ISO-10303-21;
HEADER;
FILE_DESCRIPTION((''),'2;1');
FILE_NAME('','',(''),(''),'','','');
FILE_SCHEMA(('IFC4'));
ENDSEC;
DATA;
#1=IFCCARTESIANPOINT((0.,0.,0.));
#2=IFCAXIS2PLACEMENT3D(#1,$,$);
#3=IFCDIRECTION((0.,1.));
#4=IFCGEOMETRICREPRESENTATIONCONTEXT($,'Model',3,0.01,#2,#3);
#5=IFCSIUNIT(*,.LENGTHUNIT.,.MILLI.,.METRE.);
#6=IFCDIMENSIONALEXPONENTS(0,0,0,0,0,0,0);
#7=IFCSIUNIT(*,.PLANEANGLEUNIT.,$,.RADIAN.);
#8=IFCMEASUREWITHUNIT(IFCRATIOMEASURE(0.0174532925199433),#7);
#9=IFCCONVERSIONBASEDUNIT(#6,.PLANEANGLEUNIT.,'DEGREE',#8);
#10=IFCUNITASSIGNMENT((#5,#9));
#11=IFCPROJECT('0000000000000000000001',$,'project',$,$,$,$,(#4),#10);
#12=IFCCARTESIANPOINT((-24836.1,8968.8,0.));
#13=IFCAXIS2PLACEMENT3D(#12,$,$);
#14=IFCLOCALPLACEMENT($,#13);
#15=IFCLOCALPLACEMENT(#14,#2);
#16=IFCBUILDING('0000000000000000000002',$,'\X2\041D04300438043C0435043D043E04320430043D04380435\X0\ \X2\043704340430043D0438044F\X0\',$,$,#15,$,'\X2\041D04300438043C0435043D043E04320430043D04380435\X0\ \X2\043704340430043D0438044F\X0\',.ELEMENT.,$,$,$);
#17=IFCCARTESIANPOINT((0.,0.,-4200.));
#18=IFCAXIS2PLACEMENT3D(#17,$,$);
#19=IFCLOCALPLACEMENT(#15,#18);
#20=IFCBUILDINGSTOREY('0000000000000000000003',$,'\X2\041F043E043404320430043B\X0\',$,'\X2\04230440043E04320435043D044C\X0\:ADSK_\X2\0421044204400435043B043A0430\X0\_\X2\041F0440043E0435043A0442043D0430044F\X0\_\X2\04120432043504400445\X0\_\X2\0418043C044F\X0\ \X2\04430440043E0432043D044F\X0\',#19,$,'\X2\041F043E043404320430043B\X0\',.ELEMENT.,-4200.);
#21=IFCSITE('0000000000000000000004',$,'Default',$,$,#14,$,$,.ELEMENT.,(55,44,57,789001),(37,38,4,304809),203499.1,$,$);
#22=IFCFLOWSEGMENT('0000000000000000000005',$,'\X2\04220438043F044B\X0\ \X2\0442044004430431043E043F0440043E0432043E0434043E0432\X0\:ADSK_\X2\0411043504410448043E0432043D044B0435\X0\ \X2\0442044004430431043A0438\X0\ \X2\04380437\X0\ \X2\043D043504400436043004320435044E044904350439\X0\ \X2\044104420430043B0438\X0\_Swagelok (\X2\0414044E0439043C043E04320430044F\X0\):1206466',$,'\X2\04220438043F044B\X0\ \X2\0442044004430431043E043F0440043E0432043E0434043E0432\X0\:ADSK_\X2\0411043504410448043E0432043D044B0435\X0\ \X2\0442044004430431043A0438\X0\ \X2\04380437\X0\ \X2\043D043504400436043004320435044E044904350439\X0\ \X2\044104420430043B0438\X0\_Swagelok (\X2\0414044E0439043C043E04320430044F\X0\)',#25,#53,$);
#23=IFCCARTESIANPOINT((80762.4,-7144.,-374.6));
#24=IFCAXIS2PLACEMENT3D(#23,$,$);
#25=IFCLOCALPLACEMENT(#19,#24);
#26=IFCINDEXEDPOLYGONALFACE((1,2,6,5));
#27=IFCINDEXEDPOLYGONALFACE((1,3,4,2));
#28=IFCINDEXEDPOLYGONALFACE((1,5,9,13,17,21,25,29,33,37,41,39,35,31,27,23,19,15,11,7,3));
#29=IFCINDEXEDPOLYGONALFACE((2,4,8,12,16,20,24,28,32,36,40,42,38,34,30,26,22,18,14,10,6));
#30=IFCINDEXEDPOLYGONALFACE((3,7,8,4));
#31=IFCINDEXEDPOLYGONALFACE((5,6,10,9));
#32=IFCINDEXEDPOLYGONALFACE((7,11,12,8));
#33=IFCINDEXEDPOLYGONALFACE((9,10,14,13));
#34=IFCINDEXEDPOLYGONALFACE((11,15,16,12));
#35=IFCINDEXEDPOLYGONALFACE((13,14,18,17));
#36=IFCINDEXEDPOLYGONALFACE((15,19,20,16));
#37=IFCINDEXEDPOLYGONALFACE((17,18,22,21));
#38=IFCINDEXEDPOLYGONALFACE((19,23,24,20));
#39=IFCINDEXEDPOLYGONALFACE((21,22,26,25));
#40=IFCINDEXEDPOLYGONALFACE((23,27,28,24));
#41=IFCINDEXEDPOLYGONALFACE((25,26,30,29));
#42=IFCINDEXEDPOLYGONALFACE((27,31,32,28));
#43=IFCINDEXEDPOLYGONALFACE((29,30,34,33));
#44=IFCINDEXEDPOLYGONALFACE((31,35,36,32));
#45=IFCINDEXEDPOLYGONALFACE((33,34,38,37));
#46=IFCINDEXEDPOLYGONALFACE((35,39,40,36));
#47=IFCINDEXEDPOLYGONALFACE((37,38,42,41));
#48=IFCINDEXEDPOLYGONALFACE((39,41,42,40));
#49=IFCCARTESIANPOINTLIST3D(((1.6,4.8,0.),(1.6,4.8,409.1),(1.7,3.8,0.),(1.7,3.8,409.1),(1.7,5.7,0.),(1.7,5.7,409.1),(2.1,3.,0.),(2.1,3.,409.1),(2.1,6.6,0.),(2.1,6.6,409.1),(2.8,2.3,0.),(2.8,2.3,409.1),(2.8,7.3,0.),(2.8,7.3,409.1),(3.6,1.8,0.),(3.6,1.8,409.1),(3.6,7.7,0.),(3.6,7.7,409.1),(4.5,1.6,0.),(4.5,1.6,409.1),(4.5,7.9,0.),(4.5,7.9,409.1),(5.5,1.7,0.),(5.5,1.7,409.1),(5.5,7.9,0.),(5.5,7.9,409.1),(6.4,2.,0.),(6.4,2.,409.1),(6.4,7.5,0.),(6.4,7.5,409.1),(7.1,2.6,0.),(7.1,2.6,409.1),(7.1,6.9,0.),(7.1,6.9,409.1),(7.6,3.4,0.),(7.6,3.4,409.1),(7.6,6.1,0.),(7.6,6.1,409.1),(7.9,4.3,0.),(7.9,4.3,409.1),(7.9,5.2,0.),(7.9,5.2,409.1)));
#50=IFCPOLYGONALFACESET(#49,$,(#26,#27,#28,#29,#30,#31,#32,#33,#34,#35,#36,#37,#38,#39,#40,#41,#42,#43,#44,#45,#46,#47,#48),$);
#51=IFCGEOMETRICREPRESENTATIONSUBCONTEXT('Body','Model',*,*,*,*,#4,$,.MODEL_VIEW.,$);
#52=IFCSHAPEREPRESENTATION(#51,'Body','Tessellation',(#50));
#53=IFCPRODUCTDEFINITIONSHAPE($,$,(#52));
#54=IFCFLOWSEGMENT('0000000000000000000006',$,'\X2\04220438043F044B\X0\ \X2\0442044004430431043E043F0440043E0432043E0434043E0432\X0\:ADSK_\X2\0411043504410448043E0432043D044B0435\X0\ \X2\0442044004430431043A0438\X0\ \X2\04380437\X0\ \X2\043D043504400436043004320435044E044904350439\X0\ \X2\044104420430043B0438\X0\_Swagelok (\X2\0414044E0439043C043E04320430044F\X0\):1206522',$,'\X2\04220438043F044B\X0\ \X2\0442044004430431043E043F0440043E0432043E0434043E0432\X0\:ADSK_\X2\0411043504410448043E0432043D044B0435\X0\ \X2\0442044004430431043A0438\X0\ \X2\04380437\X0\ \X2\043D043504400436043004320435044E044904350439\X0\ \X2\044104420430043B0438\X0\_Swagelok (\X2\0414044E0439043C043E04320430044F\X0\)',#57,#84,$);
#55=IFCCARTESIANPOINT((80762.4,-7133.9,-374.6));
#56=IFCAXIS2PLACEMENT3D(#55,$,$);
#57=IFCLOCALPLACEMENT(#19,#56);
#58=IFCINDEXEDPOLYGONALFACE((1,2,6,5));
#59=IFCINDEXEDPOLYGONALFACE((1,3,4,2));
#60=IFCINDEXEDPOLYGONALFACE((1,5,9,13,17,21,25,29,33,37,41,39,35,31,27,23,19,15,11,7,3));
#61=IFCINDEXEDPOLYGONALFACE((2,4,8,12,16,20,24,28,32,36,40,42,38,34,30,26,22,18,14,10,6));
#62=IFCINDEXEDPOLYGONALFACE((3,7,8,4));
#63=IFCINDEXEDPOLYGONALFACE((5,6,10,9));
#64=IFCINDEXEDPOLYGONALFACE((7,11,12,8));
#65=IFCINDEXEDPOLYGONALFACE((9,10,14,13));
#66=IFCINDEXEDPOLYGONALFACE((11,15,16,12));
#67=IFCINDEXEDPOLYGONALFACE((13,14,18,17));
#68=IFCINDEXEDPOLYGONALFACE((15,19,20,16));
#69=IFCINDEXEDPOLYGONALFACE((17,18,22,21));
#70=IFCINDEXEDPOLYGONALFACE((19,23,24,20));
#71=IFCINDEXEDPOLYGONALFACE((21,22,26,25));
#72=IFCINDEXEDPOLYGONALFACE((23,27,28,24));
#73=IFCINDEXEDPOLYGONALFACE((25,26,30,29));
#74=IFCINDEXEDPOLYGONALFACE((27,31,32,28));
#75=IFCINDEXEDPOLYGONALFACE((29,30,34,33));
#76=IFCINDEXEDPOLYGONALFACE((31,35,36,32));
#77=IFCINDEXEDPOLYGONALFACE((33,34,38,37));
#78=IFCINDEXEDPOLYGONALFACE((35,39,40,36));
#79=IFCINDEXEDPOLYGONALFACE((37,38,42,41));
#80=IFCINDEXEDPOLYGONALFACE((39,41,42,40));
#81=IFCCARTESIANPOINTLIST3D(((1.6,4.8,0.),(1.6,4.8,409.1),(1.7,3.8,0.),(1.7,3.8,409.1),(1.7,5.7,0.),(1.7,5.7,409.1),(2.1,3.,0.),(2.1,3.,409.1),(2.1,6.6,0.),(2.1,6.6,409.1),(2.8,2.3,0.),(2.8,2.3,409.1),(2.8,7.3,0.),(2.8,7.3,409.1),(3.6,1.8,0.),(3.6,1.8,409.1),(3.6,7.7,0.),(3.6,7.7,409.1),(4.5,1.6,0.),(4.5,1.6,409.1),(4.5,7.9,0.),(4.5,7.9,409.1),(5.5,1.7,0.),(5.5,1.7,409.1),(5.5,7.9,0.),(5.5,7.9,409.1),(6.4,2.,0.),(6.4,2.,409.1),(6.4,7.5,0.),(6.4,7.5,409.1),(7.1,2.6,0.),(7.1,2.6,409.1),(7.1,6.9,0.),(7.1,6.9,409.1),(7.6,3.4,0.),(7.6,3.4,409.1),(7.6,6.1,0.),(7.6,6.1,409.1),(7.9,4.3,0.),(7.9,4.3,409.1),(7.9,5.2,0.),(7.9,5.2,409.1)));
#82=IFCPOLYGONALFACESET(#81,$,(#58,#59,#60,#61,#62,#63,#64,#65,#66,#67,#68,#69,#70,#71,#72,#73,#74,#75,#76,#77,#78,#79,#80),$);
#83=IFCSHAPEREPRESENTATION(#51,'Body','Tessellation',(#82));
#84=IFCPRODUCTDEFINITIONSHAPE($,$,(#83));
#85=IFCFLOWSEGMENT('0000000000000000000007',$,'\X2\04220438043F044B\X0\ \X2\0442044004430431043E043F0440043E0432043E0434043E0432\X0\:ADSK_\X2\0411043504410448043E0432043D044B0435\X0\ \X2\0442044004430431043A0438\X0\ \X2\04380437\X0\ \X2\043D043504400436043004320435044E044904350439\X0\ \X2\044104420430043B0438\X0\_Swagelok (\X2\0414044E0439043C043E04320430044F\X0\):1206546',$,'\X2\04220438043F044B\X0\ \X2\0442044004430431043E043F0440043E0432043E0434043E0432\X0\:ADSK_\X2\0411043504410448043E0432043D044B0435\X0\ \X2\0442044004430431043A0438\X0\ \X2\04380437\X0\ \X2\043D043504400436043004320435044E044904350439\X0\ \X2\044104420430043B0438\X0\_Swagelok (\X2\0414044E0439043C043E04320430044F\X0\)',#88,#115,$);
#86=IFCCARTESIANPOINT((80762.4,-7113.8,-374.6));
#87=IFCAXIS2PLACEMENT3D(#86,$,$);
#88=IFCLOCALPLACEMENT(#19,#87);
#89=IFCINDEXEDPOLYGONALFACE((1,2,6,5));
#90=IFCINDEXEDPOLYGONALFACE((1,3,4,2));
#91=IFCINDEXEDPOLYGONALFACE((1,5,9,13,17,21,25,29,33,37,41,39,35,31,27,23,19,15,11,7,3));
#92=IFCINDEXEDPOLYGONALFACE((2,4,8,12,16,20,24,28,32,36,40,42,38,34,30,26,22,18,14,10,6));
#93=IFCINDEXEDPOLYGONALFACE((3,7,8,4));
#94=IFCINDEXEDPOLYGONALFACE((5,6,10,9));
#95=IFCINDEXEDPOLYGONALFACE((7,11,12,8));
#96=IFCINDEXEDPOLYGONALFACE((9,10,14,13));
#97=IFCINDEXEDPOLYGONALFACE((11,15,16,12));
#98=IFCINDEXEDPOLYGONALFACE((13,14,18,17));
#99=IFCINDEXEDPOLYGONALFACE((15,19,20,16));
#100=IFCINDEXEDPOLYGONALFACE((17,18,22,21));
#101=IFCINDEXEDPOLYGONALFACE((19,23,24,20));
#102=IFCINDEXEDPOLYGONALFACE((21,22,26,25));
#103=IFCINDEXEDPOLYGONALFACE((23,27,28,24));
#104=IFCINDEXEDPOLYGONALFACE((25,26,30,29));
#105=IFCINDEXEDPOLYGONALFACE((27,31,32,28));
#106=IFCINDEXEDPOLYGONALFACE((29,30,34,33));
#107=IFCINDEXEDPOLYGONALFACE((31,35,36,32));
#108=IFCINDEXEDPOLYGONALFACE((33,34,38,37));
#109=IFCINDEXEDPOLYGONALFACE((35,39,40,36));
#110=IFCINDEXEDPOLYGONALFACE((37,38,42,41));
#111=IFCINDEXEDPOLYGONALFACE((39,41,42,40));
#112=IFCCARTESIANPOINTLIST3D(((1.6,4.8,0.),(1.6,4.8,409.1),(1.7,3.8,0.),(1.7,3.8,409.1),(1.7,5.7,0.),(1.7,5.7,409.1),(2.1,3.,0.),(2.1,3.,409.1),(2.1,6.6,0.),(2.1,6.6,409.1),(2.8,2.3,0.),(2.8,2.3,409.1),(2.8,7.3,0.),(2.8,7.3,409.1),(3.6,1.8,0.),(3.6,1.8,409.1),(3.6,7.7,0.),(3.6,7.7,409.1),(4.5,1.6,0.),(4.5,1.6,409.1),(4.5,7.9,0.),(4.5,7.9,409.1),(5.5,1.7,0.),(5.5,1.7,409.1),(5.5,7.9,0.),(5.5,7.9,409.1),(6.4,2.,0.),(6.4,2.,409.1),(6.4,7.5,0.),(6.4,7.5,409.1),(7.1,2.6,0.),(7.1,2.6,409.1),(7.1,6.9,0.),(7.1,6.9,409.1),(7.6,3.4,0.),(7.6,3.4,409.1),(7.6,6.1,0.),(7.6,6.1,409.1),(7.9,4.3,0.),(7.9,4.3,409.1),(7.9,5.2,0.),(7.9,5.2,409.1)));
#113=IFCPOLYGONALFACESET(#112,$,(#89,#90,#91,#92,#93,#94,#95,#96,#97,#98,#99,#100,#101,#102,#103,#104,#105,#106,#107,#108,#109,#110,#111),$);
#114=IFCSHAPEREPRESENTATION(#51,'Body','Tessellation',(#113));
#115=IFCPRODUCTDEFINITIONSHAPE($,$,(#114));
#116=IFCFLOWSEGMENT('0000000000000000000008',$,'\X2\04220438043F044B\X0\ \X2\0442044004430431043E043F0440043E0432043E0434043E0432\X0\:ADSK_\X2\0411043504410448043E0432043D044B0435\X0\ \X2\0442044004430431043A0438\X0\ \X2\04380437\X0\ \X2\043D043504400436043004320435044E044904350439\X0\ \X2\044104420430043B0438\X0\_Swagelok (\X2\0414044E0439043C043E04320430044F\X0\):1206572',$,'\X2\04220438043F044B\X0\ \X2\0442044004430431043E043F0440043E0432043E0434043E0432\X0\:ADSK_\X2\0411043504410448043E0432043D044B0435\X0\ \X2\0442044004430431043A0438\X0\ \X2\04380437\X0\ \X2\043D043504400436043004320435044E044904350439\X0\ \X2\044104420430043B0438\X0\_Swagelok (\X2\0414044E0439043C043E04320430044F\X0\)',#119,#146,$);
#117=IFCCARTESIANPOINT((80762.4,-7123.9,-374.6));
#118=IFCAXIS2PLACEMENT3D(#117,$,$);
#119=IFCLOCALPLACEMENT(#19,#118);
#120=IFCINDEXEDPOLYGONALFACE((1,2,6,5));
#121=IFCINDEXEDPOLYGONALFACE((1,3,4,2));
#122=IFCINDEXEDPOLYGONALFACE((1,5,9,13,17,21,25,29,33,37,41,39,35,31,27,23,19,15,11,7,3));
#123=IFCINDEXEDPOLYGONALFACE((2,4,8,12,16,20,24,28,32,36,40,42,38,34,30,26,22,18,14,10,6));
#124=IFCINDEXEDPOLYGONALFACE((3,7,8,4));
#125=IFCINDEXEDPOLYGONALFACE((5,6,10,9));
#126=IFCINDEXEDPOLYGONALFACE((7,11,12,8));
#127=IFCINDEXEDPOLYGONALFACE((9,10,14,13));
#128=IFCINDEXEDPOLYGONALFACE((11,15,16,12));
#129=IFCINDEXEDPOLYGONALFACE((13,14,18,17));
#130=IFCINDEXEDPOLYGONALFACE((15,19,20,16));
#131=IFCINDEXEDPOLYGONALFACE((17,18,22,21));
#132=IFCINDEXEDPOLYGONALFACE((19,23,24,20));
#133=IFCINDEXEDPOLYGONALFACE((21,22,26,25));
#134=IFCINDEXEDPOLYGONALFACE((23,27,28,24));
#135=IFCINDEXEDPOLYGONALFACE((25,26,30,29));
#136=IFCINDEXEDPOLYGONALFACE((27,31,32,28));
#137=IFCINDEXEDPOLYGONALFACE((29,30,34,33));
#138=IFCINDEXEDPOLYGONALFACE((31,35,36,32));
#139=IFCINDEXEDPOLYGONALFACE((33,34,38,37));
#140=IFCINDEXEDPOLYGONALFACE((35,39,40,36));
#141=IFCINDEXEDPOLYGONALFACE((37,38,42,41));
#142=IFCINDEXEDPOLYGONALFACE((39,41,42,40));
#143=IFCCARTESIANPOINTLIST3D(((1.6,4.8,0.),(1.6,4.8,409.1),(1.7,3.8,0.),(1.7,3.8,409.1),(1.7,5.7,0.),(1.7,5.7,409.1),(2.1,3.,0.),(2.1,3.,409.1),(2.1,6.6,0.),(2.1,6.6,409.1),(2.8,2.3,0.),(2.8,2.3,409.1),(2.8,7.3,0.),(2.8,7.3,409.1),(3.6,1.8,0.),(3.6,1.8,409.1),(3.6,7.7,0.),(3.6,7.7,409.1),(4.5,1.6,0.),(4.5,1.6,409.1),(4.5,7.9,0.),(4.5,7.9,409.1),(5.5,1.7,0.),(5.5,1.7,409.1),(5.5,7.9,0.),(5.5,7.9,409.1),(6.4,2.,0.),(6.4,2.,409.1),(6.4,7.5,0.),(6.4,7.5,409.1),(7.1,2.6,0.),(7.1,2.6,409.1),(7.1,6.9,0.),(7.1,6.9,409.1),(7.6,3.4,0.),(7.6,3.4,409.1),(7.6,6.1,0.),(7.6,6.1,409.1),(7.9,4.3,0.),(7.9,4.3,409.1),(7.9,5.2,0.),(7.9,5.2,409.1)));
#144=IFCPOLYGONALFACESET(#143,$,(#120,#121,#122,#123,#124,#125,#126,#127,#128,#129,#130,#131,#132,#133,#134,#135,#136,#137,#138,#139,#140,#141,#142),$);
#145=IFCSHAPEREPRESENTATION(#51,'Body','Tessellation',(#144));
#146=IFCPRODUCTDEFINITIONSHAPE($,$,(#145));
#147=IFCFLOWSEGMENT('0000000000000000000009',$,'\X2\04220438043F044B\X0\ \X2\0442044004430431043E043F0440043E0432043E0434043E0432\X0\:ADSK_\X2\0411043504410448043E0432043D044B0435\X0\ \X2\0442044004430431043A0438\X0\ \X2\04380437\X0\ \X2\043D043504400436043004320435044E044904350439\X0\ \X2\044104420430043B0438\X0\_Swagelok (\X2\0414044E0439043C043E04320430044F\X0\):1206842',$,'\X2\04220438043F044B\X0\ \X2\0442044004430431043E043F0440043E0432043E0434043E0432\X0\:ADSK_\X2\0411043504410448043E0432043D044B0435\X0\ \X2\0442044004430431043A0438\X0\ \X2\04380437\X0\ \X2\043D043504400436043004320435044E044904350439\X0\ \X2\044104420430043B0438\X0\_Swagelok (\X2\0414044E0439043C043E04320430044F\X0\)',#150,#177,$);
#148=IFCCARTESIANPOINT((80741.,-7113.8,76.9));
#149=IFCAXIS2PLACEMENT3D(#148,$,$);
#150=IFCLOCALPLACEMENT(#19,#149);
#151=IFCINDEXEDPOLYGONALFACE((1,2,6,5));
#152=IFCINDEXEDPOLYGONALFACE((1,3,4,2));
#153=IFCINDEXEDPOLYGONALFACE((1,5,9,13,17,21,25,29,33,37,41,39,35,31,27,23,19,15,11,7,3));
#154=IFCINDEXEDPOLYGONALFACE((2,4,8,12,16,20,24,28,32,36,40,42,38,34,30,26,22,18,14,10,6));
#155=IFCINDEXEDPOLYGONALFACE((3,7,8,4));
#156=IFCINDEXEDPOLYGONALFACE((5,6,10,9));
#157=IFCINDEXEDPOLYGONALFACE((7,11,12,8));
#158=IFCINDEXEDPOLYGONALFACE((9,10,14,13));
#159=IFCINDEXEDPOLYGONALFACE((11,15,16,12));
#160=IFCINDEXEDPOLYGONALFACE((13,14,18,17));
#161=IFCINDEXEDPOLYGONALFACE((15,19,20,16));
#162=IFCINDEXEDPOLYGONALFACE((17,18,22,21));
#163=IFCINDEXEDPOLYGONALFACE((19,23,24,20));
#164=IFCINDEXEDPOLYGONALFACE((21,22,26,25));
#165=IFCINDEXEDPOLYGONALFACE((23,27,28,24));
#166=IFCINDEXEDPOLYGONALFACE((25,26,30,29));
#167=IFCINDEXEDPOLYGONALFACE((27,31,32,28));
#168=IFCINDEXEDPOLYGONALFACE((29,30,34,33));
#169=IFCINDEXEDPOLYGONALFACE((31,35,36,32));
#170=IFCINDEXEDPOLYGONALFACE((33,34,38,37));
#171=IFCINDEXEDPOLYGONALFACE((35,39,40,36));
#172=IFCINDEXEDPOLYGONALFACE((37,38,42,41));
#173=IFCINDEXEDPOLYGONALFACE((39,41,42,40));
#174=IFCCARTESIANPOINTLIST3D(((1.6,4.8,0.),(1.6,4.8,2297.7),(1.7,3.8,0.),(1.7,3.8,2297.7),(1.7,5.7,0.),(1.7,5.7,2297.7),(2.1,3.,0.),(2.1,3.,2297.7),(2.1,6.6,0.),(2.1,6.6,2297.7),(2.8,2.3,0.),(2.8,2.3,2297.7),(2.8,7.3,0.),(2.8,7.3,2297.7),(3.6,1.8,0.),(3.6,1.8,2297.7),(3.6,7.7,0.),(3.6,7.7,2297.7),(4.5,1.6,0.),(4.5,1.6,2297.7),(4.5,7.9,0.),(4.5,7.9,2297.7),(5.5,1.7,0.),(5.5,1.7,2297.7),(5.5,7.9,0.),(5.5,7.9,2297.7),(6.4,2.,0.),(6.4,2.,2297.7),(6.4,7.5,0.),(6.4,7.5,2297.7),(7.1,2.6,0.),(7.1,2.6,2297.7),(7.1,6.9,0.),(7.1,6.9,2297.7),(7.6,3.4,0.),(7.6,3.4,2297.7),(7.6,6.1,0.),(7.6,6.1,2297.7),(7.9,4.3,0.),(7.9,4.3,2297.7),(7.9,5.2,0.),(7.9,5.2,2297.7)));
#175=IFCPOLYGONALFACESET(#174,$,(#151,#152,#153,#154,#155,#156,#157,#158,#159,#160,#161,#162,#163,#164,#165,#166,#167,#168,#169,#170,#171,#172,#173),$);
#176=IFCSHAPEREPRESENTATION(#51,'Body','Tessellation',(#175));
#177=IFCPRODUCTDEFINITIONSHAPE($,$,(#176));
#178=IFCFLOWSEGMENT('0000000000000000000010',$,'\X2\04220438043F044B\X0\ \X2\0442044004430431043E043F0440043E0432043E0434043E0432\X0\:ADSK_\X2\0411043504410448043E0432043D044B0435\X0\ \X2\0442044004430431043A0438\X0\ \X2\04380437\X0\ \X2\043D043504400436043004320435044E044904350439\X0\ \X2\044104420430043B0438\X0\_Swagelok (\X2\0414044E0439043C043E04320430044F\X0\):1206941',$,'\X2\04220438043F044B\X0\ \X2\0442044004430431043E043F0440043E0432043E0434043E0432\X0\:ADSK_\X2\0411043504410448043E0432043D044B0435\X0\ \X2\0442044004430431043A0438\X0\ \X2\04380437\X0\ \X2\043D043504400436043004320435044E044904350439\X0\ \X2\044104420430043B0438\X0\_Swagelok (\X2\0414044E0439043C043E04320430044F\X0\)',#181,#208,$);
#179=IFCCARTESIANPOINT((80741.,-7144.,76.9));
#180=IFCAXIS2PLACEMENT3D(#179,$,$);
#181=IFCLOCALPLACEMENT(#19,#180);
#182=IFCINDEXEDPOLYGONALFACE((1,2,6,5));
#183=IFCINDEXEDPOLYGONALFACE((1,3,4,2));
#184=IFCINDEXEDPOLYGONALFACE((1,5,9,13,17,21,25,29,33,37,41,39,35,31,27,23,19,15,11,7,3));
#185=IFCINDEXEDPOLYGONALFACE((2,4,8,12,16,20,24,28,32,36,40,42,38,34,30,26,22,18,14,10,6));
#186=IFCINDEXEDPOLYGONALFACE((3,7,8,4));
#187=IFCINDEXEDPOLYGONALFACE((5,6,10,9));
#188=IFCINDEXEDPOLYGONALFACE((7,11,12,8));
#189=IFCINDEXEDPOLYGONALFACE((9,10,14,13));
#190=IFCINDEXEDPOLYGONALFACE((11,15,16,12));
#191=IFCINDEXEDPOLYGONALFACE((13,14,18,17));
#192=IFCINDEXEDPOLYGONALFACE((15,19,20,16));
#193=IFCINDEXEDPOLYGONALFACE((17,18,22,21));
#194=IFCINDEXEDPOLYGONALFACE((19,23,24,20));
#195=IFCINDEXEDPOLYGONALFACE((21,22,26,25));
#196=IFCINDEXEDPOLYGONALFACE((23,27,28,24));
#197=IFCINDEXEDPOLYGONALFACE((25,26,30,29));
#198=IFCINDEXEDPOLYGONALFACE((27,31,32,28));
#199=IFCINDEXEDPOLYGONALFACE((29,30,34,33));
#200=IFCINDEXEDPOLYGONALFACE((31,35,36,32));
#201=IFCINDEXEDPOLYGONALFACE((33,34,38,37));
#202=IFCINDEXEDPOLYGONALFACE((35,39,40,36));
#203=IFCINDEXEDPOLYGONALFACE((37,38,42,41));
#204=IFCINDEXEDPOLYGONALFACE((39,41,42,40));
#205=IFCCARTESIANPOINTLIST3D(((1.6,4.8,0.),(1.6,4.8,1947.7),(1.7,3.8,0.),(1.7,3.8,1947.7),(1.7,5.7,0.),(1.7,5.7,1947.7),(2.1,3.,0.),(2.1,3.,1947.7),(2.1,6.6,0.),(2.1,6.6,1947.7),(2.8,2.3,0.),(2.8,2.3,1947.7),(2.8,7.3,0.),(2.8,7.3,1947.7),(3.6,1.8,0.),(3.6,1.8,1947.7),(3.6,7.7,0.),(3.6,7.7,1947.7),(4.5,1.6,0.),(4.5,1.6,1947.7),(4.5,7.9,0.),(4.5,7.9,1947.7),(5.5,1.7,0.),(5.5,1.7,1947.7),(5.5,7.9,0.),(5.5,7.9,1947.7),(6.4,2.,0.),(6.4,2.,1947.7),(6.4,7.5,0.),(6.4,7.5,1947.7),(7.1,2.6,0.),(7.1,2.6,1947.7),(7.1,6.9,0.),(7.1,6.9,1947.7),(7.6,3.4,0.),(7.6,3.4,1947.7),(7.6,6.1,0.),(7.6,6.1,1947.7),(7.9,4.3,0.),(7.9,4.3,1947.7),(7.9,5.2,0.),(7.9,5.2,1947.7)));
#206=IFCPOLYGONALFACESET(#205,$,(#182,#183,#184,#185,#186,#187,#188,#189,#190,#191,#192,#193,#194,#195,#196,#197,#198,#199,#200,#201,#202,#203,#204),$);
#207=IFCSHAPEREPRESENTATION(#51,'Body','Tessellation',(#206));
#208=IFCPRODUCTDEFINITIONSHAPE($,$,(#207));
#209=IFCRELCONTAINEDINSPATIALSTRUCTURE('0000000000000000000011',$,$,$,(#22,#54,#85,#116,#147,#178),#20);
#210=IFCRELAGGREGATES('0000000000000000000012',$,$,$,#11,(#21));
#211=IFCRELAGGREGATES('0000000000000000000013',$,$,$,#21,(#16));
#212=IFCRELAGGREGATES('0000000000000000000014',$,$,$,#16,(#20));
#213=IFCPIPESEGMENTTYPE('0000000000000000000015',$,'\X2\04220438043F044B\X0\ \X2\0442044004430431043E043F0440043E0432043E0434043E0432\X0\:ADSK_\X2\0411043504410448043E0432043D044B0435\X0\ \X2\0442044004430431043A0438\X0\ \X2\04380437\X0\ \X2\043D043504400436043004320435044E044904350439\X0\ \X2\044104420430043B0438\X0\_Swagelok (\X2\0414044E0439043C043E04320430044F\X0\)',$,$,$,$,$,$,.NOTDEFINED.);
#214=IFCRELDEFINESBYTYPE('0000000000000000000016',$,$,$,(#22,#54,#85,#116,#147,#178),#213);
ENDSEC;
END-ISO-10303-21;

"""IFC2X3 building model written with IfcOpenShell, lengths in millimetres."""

from ifc_helpers import new_model, entity, si_unit, converted_unit, direction, frame, origin, origin_2d_with_axis, place, context, subcontext, project, spatial, circle, extrude, type_object, element, save


model = new_model("IFC2X3")

# Units and contexts
model_context = context("Model", 3, precision=0.01, world=origin(), true_north=direction((0.0, 1.0)))
body_context = subcontext(model_context, "Body", "Model", "MODEL_VIEW")
ifc_project = project(units=[si_unit("LENGTHUNIT", "METRE", prefix="MILLI"), converted_unit("PLANEANGLEUNIT", "DEGREE", entity("IfcRatioMeasure", 0.0174532925199433), si_unit("PLANEANGLEUNIT", "RADIAN"), dimensions=[0, 0, 0, 0, 0, 0, 0])], contexts=[model_context])

# Site, building, storey
site_placement = place(None, frame((-24836.1, 8968.8, 0.0)))
site = spatial("IfcSite", under=ifc_project, at=site_placement, Name="Default", CompositionType="ELEMENT", RefLatitude=(55, 44, 57, 789001), RefLongitude=(37, 38, 4, 304809), RefElevation=203499.1)
building_placement = place(site_placement, origin())
building = spatial("IfcBuilding", under=site, at=building_placement, Name="Наименование здания", LongName="Наименование здания", CompositionType="ELEMENT")
storey_placement = place(building_placement, frame((0.0, 0.0, -4200.0)))
storey = spatial("IfcBuildingStorey", under=building, at=storey_placement, Name="Подвал", ObjectType="Уровень:ADSK_Стрелка_Проектная_Вверх_Имя уровня", LongName="Подвал", CompositionType="ELEMENT", Elevation=-4200.0)

# Flow segments
pipe_segment_type_1 = type_object("IfcPipeSegmentType", Name="Типы трубопроводов:ADSK_Бесшовные трубки из нержавеющей стали_Swagelok (Дюймовая)", PredefinedType="NOTDEFINED")
flow_segment_1_placement = place(storey_placement, frame((80762.4, -7144.0, -374.6)))
element("IfcFlowSegment", 1, at=flow_segment_1_placement, inside=storey, type_object=pipe_segment_type_1, Name="Типы трубопроводов:ADSK_Бесшовные трубки из нержавеющей стали_Swagelok (Дюймовая):1206466", ObjectType="Типы трубопроводов:ADSK_Бесшовные трубки из нержавеющей стали_Swagelok (Дюймовая)", context=body_context, shape_type="SweptSolid", body=[
    extrude(circle(Radius=3.2, at=origin_2d_with_axis()), frame((4.8, 4.8, 0.0), z_axis=(0.0, 0.0, 1.0), x_axis=(-1.0, 0.0, 0.0)), (0.0, 0.0, 1.0), 409.1),
])
flow_segment_2_placement = place(storey_placement, frame((80762.4, -7133.9, -374.6)))
element("IfcFlowSegment", 2, at=flow_segment_2_placement, inside=storey, type_object=pipe_segment_type_1, Name="Типы трубопроводов:ADSK_Бесшовные трубки из нержавеющей стали_Swagelok (Дюймовая):1206522", ObjectType="Типы трубопроводов:ADSK_Бесшовные трубки из нержавеющей стали_Swagelok (Дюймовая)", context=body_context, shape_type="SweptSolid", body=[
    extrude(circle(Radius=3.2, at=origin_2d_with_axis()), frame((4.8, 4.8, 0.0), z_axis=(0.0, 0.0, 1.0), x_axis=(-1.0, 0.0, 0.0)), (0.0, 0.0, 1.0), 409.1),
])
flow_segment_3_placement = place(storey_placement, frame((80762.4, -7113.8, -374.6)))
element("IfcFlowSegment", 3, at=flow_segment_3_placement, inside=storey, type_object=pipe_segment_type_1, Name="Типы трубопроводов:ADSK_Бесшовные трубки из нержавеющей стали_Swagelok (Дюймовая):1206546", ObjectType="Типы трубопроводов:ADSK_Бесшовные трубки из нержавеющей стали_Swagelok (Дюймовая)", context=body_context, shape_type="SweptSolid", body=[
    extrude(circle(Radius=3.2, at=origin_2d_with_axis()), frame((4.8, 4.8, 0.0), z_axis=(0.0, 0.0, 1.0), x_axis=(-1.0, 0.0, 0.0)), (0.0, 0.0, 1.0), 409.1),
])
flow_segment_4_placement = place(storey_placement, frame((80762.4, -7123.9, -374.6)))
element("IfcFlowSegment", 4, at=flow_segment_4_placement, inside=storey, type_object=pipe_segment_type_1, Name="Типы трубопроводов:ADSK_Бесшовные трубки из нержавеющей стали_Swagelok (Дюймовая):1206572", ObjectType="Типы трубопроводов:ADSK_Бесшовные трубки из нержавеющей стали_Swagelok (Дюймовая)", context=body_context, shape_type="SweptSolid", body=[
    extrude(circle(Radius=3.2, at=origin_2d_with_axis()), frame((4.8, 4.8, 0.0), z_axis=(0.0, 0.0, 1.0), x_axis=(-1.0, 0.0, 0.0)), (0.0, 0.0, 1.0), 409.1),
])
flow_segment_5_placement = place(storey_placement, frame((80741.0, -7113.8, 76.9)))
element("IfcFlowSegment", 5, at=flow_segment_5_placement, inside=storey, type_object=pipe_segment_type_1, Name="Типы трубопроводов:ADSK_Бесшовные трубки из нержавеющей стали_Swagelok (Дюймовая):1206842", ObjectType="Типы трубопроводов:ADSK_Бесшовные трубки из нержавеющей стали_Swagelok (Дюймовая)", context=body_context, shape_type="SweptSolid", body=[
    extrude(circle(Radius=3.2, at=origin_2d_with_axis()), frame((4.8, 4.8, 0.0), z_axis=(0.0, 0.0, 1.0), x_axis=(-1.0, 0.0, 0.0)), (0.0, 0.0, 1.0), 2297.7),
])
flow_segment_6_placement = place(storey_placement, frame((80741.0, -7144.0, 76.9)))
element("IfcFlowSegment", 6, at=flow_segment_6_placement, inside=storey, type_object=pipe_segment_type_1, Name="Типы трубопроводов:ADSK_Бесшовные трубки из нержавеющей стали_Swagelok (Дюймовая):1206941", ObjectType="Типы трубопроводов:ADSK_Бесшовные трубки из нержавеющей стали_Swagelok (Дюймовая)", context=body_context, shape_type="SweptSolid", body=[
    extrude(circle(Radius=3.2, at=origin_2d_with_axis()), frame((4.8, 4.8, 0.0), z_axis=(0.0, 0.0, 1.0), x_axis=(-1.0, 0.0, 0.0)), (0.0, 0.0, 1.0), 1947.7),
])

save(model, "model.ifc")
